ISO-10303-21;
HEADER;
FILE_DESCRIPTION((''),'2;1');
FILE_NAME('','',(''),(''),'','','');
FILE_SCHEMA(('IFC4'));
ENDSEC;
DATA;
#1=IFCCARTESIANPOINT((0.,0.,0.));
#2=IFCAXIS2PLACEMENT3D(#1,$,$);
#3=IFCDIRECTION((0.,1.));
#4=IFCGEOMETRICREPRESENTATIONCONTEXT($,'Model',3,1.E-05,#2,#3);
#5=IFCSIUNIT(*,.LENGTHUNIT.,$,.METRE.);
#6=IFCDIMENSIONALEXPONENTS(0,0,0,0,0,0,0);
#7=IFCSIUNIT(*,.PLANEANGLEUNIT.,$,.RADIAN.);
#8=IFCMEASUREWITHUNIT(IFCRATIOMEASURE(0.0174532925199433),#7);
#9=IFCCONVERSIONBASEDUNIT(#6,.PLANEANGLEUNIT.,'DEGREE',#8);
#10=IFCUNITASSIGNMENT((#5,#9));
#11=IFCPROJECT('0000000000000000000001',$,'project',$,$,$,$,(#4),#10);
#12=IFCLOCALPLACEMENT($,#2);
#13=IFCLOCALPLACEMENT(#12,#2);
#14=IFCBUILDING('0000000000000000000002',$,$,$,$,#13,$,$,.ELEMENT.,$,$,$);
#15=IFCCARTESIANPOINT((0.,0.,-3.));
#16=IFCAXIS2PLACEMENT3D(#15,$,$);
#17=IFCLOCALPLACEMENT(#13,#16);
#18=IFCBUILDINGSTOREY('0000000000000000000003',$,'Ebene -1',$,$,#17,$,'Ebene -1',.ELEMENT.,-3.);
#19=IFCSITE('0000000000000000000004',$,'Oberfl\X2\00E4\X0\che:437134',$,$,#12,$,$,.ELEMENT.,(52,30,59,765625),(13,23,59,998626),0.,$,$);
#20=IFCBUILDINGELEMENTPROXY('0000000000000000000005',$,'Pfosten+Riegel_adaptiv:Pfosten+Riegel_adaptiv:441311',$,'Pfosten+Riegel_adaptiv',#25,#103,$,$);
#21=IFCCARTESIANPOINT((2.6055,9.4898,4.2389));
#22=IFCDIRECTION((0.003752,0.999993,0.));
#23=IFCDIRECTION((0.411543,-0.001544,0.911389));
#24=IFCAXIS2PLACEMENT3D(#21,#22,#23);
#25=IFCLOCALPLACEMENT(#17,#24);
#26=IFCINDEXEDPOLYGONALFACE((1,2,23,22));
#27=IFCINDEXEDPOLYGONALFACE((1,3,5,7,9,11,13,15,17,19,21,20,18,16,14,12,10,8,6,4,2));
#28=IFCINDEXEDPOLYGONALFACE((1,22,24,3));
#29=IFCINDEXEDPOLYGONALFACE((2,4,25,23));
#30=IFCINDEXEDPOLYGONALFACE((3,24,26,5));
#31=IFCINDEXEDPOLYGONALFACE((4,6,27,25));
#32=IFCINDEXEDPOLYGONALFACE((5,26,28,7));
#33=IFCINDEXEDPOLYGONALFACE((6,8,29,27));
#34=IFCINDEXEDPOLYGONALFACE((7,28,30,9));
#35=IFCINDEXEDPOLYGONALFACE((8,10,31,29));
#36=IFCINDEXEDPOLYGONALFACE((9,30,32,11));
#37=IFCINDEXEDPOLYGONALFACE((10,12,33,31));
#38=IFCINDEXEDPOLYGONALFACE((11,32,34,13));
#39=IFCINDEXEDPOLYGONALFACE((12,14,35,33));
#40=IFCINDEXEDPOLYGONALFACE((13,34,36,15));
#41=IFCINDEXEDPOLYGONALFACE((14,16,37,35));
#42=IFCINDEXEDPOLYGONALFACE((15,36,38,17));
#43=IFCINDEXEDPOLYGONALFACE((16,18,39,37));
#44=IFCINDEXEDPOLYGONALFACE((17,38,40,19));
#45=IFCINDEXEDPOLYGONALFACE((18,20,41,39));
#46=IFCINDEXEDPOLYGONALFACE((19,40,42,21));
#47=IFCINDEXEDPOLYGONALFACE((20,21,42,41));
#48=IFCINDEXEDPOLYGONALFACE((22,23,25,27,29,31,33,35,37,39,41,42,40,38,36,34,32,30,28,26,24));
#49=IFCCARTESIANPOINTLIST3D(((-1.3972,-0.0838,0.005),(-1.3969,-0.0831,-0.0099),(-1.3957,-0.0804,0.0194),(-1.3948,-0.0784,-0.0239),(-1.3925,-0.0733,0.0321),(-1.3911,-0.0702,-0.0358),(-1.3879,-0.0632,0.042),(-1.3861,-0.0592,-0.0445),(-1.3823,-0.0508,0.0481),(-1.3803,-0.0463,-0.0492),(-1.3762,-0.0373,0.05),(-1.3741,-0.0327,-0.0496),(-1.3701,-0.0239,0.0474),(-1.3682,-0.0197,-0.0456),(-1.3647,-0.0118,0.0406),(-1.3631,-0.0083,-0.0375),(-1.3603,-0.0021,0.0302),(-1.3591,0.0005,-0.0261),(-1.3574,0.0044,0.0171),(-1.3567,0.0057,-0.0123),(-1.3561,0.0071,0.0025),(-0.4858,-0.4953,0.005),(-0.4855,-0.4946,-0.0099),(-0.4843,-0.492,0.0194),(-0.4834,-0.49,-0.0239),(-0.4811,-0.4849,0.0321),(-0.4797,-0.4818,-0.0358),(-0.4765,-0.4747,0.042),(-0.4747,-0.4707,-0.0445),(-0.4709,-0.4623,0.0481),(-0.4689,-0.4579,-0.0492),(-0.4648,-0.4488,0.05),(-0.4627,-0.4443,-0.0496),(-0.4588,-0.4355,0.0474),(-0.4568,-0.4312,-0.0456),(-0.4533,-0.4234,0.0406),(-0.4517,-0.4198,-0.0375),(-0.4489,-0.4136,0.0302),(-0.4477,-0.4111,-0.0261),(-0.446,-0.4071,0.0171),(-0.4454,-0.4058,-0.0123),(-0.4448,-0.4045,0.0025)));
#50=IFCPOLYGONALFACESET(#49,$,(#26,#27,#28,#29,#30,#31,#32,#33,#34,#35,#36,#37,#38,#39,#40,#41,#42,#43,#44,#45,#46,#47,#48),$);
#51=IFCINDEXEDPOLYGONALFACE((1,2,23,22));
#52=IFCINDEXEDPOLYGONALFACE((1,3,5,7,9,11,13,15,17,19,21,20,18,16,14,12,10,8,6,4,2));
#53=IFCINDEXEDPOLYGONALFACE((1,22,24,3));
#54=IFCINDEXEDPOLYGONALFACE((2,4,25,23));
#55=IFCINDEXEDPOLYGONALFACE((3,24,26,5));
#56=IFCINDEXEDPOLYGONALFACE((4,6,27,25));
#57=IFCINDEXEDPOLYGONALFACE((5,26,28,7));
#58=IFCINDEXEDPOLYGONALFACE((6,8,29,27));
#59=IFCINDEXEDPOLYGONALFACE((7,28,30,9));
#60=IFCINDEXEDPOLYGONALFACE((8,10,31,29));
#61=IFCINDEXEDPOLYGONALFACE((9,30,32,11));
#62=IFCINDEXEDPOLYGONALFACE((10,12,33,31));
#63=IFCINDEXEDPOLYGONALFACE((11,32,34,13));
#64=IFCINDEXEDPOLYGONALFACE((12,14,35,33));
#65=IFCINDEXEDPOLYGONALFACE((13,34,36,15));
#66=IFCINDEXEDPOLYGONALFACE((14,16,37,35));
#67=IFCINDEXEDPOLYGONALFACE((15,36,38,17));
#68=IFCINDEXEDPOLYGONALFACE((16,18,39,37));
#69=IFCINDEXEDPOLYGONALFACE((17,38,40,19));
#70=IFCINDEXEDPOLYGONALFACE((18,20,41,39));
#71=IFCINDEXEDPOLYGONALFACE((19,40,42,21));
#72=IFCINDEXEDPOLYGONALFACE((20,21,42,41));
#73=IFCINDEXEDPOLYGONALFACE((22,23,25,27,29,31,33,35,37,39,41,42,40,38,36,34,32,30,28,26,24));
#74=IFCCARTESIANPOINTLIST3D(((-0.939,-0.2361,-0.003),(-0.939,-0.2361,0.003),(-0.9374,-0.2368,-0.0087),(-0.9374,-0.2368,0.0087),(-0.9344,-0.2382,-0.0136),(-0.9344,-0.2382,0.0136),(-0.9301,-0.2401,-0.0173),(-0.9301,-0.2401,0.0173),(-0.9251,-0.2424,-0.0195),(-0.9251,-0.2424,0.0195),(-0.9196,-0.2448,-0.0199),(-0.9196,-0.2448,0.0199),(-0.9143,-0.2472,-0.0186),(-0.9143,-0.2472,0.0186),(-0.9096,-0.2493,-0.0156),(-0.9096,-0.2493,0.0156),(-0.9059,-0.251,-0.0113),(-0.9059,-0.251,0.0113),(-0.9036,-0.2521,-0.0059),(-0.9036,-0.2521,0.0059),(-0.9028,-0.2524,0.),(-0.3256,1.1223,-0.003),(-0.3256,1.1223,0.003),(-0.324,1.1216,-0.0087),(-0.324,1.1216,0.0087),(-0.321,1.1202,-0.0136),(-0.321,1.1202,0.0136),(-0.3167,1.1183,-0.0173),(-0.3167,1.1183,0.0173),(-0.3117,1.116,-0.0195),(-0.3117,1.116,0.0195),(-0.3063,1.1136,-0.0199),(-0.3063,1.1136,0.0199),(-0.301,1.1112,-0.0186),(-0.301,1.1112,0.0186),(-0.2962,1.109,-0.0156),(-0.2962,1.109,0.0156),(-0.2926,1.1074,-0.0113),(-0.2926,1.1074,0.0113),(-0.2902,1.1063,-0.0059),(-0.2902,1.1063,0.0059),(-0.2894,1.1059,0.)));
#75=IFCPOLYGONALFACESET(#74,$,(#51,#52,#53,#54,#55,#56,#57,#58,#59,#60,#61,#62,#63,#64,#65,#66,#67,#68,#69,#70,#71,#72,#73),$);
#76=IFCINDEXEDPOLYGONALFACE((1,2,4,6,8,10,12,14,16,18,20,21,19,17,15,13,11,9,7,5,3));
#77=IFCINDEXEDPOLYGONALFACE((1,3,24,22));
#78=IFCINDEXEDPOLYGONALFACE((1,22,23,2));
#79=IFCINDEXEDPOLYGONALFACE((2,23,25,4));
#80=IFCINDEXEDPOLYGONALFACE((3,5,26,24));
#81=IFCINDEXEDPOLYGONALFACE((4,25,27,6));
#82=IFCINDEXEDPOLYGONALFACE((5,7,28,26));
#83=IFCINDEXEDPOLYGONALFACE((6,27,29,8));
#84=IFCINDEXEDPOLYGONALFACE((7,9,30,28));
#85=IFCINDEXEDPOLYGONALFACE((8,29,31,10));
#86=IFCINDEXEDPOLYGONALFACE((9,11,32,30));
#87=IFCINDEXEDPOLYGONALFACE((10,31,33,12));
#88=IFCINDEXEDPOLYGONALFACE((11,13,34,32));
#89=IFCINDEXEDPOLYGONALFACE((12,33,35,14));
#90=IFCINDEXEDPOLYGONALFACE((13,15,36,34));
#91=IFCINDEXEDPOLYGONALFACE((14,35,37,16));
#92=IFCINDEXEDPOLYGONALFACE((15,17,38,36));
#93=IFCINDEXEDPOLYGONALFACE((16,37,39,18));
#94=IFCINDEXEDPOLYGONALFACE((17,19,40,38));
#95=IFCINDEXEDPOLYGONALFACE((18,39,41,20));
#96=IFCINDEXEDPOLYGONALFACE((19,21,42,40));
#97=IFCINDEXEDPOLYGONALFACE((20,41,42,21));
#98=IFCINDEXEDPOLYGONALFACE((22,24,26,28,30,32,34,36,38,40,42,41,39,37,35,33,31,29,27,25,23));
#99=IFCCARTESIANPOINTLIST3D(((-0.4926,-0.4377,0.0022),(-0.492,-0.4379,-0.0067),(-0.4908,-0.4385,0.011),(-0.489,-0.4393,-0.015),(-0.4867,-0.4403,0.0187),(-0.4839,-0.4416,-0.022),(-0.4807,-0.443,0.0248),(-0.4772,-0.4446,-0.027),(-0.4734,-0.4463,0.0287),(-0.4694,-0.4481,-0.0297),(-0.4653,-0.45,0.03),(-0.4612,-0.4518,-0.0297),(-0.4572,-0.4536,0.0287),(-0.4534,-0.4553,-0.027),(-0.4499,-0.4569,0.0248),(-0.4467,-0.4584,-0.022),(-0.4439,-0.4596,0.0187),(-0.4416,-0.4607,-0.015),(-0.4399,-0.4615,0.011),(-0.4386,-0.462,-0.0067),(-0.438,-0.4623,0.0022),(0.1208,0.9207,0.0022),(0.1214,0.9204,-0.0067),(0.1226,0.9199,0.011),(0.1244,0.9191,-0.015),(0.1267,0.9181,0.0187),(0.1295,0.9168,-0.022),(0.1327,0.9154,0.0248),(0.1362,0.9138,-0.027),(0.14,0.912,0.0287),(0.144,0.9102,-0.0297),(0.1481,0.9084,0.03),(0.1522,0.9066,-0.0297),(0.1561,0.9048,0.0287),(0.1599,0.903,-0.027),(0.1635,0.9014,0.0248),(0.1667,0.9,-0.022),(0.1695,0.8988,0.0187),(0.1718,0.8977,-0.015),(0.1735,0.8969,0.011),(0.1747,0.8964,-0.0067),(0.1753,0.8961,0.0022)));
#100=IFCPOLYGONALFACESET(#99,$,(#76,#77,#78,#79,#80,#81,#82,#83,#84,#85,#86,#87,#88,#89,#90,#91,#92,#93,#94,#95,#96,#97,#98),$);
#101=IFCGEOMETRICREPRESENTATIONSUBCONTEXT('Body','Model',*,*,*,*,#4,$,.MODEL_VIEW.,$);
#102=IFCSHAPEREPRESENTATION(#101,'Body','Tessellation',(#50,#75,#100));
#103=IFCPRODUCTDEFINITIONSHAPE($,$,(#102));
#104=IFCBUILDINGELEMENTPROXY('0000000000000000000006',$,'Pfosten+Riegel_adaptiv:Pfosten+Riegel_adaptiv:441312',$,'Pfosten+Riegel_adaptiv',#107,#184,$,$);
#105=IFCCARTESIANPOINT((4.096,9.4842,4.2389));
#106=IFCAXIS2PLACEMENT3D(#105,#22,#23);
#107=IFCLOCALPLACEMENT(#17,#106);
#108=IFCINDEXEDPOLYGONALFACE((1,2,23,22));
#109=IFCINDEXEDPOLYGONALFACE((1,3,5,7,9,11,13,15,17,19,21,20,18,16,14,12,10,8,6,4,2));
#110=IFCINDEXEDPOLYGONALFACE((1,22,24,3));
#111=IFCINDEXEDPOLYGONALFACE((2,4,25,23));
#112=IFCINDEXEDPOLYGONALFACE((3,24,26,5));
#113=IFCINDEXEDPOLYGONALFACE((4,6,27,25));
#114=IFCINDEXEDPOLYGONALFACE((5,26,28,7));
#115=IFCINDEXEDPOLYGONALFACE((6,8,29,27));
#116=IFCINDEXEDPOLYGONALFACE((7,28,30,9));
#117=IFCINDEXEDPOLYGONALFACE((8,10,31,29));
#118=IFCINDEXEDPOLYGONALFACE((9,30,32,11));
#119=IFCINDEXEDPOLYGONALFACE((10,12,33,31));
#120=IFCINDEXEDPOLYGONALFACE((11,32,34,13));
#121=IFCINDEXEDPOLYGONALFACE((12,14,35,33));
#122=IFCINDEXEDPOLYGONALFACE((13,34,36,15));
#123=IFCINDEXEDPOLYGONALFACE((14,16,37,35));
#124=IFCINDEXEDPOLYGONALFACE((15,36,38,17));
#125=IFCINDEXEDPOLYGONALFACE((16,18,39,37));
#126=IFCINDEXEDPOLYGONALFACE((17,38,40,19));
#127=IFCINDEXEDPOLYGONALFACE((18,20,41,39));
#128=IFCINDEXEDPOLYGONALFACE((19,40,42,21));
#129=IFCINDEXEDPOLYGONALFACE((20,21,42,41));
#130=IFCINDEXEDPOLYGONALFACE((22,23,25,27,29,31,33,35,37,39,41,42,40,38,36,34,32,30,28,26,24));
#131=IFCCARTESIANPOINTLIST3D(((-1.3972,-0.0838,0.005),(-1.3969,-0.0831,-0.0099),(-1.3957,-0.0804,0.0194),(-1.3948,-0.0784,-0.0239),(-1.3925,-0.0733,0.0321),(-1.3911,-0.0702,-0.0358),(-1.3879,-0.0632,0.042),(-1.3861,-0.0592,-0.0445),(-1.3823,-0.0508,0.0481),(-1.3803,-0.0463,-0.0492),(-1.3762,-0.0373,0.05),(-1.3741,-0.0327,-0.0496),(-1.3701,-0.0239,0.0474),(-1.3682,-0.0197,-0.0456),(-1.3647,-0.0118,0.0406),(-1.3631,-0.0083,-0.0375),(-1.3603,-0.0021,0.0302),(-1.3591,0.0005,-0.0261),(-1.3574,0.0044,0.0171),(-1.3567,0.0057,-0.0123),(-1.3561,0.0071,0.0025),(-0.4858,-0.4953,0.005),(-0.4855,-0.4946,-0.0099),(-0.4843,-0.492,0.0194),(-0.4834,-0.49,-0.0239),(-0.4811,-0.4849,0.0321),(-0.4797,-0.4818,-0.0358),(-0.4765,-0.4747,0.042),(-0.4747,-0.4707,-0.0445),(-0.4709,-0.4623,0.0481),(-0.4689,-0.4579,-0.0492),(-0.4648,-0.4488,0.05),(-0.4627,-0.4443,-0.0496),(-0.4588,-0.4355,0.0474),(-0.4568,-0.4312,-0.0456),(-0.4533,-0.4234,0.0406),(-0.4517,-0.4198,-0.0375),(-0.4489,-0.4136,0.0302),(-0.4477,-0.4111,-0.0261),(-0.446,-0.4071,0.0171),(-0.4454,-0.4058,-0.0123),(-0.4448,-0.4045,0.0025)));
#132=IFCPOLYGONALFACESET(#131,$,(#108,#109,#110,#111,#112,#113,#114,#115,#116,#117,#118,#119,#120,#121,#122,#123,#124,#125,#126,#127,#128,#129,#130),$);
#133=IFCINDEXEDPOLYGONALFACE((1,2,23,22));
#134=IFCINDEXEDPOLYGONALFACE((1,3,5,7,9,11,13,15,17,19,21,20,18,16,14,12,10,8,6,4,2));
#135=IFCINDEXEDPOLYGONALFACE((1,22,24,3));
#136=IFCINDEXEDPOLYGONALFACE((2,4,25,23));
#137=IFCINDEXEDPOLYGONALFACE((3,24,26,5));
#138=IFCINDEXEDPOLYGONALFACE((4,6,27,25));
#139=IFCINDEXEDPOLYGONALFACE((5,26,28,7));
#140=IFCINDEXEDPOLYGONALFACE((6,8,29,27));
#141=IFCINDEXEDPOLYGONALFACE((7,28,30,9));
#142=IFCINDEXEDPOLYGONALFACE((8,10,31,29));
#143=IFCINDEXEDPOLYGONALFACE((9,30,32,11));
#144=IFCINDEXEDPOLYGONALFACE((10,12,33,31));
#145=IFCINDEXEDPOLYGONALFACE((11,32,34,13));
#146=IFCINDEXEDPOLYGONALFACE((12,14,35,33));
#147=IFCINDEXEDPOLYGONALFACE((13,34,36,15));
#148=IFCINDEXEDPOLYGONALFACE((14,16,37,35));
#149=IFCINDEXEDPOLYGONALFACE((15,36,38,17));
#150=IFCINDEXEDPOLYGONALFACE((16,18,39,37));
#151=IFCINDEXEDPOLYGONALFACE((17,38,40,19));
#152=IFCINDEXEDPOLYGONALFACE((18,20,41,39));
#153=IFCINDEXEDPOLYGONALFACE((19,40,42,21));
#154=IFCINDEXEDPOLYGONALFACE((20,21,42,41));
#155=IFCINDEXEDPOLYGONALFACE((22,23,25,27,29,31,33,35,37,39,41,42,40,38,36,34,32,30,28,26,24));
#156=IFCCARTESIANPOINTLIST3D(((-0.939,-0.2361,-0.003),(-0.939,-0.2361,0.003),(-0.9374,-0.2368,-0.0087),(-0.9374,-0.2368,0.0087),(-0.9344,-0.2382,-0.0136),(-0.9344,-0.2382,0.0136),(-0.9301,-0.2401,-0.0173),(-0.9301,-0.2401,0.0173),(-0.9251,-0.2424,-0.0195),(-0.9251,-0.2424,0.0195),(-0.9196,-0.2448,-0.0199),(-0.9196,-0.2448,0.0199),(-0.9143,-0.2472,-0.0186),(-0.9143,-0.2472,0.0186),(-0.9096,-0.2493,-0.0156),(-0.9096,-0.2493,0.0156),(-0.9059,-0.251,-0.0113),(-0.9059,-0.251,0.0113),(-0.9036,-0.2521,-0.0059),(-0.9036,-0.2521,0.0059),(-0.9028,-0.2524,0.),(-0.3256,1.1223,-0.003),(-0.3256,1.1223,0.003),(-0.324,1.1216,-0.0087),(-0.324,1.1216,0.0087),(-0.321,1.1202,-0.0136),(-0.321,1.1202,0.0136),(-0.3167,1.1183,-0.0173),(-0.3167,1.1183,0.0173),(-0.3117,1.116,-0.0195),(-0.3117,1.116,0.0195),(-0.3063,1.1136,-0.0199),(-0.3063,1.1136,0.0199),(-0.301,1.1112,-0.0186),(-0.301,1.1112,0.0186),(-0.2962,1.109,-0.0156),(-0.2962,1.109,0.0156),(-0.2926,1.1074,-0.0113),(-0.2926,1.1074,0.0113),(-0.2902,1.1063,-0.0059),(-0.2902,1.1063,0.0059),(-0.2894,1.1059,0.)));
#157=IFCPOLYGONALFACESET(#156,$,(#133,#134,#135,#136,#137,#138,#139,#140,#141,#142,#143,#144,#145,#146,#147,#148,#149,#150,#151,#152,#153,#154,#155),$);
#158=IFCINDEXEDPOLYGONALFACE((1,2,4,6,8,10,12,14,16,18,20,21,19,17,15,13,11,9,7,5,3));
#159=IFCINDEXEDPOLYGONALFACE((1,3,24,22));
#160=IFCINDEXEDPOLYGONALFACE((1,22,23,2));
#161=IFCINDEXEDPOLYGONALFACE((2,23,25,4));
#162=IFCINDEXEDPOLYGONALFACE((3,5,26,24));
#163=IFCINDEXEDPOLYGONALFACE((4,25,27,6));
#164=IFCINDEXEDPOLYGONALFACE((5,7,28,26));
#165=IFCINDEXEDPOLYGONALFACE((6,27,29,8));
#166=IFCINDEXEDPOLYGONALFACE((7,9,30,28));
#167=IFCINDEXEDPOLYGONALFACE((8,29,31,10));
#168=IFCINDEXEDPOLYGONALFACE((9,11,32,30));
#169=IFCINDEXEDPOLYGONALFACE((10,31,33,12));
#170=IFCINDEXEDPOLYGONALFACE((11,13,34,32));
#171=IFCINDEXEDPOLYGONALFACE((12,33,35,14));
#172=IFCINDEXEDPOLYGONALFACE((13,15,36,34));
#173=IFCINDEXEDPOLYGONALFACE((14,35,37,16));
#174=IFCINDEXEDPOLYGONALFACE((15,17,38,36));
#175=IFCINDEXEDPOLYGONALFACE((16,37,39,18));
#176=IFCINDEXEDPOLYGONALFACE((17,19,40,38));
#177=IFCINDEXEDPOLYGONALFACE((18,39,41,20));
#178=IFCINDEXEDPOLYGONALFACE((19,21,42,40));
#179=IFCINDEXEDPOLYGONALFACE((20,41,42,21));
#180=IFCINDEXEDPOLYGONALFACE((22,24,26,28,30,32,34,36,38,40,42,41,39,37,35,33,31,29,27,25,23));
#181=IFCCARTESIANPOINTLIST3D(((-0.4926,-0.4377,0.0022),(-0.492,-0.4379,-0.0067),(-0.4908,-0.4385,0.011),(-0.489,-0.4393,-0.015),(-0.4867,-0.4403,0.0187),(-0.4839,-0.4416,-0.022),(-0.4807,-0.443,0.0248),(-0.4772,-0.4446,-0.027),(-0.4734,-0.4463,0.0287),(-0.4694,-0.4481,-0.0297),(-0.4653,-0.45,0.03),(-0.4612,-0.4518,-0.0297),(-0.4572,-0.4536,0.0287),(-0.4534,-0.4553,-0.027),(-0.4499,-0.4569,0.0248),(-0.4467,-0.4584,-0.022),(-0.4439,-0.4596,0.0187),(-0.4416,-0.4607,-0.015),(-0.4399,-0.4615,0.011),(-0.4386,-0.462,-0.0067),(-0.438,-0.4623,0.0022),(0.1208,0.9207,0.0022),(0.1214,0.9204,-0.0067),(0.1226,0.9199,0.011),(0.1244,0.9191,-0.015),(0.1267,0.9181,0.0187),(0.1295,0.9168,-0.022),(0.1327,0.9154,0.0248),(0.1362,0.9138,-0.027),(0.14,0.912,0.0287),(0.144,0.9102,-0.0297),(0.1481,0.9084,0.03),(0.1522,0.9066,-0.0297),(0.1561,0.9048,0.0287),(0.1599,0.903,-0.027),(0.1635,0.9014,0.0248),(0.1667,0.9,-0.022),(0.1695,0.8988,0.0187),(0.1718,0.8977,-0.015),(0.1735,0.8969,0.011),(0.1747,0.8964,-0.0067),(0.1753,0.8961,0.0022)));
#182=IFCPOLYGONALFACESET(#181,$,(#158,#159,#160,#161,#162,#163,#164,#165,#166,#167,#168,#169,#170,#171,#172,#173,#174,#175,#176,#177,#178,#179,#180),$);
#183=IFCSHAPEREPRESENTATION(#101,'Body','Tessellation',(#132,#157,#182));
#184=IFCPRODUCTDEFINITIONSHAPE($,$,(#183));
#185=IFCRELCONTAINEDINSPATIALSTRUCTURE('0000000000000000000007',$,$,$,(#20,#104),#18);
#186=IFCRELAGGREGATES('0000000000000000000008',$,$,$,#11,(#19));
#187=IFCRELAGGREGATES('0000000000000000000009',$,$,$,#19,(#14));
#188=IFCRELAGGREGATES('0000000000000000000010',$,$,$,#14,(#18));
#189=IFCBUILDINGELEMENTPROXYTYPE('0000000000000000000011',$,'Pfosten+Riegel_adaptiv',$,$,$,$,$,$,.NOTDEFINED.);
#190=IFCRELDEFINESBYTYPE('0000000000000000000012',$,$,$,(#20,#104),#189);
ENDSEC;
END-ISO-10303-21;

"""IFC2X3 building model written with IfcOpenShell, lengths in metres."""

from ifc_helpers import new_model, entity, si_unit, converted_unit, direction, frame, frame_2d, origin, place, context, subcontext, project, spatial, circle, extrude, source, transform, mapped, type_object, type_shapes, element, save


model = new_model("IFC2X3")

# Units and contexts
model_context = context("Model", 3, precision=1e-05, world=origin(), true_north=direction((0.0, 1.0)))
body_context = subcontext(model_context, "Body", "Model", "MODEL_VIEW")
ifc_project = project(units=[si_unit("LENGTHUNIT", "METRE"), converted_unit("PLANEANGLEUNIT", "DEGREE", entity("IfcRatioMeasure", 0.0174532925199433), si_unit("PLANEANGLEUNIT", "RADIAN"), dimensions=[0, 0, 0, 0, 0, 0, 0])], contexts=[model_context])

# Site, building, storey
site_placement = place(None, origin())
site = spatial("IfcSite", under=ifc_project, at=site_placement, Name="Oberfläche:437134", CompositionType="ELEMENT", RefLatitude=(52, 30, 59, 765625), RefLongitude=(13, 23, 59, 998626), RefElevation=0.0)
building_placement = place(site_placement, origin())
building = spatial("IfcBuilding", under=site, at=building_placement, CompositionType="ELEMENT")
storey_placement = place(building_placement, frame((0.0, 0.0, -3.0)))
storey = spatial("IfcBuildingStorey", under=building, at=storey_placement, Name="Ebene -1", LongName="Ebene -1", CompositionType="ELEMENT", Elevation=-3.0)

# Building element proxies
building_element_proxy_type_1 = type_object("IfcBuildingElementProxyType", Name="Pfosten+Riegel_adaptiv", PredefinedType="NOTDEFINED")
shared_shape_1 = source(origin(), body_context, "Body", "SweptSolid", [
    extrude(circle(Radius=0.05, at=frame_2d((0.0, 0.0), x_axis=(1.0, 0.0))), frame((-0.4653, -0.45, 0.0), z_axis=(-0.911389, 0.411546, 0.0), x_axis=(0.16937, 0.375078, -0.911389)), (0.0, 0.0, 1.0), 1.0),
    extrude(circle(Radius=0.02, at=frame_2d((0.0, 0.0), x_axis=(1.0, 0.0))), frame((-0.921, -0.2442, 0.0), z_axis=(0.411546, 0.911389, 0.0), x_axis=(0.911389, -0.411546, 0.0)), (0.0, 0.0, 1.0), 1.4904),
    extrude(circle(Radius=0.03, at=frame_2d((0.0, 0.0), x_axis=(1.0, 0.0))), frame((-0.4653, -0.45, 0.0), z_axis=(0.411546, 0.911389, 0.0), x_axis=(0.0, 0.0, 1.0)), (0.0, 0.0, 1.0), 1.4904),
])
type_shapes(building_element_proxy_type_1, [shared_shape_1])
for number, where, z_axis, x_axis, name in (
    (1, (2.6055, 9.4898, 4.2389), (0.003752, 0.999993, 0.0), (0.411543, -0.001544, 0.911389), "Pfosten+Riegel_adaptiv:Pfosten+Riegel_adaptiv:441311"),
    (2, (4.096, 9.4842, 4.2389), (0.003752, 0.999993, 0.0), (0.411543, -0.001544, 0.911389), "Pfosten+Riegel_adaptiv:Pfosten+Riegel_adaptiv:441312"),
):
    element("IfcBuildingElementProxy", number, at=place(storey_placement, frame(where, z_axis=z_axis, x_axis=x_axis)), inside=storey, type_object=building_element_proxy_type_1, Name=name, ObjectType="Pfosten+Riegel_adaptiv", context=body_context, shape_type="MappedRepresentation", body=[
        mapped(shared_shape_1, transform((0.0, 0.0, 0.0), scale=1.0)),
    ])

save(model, "model.ifc")
